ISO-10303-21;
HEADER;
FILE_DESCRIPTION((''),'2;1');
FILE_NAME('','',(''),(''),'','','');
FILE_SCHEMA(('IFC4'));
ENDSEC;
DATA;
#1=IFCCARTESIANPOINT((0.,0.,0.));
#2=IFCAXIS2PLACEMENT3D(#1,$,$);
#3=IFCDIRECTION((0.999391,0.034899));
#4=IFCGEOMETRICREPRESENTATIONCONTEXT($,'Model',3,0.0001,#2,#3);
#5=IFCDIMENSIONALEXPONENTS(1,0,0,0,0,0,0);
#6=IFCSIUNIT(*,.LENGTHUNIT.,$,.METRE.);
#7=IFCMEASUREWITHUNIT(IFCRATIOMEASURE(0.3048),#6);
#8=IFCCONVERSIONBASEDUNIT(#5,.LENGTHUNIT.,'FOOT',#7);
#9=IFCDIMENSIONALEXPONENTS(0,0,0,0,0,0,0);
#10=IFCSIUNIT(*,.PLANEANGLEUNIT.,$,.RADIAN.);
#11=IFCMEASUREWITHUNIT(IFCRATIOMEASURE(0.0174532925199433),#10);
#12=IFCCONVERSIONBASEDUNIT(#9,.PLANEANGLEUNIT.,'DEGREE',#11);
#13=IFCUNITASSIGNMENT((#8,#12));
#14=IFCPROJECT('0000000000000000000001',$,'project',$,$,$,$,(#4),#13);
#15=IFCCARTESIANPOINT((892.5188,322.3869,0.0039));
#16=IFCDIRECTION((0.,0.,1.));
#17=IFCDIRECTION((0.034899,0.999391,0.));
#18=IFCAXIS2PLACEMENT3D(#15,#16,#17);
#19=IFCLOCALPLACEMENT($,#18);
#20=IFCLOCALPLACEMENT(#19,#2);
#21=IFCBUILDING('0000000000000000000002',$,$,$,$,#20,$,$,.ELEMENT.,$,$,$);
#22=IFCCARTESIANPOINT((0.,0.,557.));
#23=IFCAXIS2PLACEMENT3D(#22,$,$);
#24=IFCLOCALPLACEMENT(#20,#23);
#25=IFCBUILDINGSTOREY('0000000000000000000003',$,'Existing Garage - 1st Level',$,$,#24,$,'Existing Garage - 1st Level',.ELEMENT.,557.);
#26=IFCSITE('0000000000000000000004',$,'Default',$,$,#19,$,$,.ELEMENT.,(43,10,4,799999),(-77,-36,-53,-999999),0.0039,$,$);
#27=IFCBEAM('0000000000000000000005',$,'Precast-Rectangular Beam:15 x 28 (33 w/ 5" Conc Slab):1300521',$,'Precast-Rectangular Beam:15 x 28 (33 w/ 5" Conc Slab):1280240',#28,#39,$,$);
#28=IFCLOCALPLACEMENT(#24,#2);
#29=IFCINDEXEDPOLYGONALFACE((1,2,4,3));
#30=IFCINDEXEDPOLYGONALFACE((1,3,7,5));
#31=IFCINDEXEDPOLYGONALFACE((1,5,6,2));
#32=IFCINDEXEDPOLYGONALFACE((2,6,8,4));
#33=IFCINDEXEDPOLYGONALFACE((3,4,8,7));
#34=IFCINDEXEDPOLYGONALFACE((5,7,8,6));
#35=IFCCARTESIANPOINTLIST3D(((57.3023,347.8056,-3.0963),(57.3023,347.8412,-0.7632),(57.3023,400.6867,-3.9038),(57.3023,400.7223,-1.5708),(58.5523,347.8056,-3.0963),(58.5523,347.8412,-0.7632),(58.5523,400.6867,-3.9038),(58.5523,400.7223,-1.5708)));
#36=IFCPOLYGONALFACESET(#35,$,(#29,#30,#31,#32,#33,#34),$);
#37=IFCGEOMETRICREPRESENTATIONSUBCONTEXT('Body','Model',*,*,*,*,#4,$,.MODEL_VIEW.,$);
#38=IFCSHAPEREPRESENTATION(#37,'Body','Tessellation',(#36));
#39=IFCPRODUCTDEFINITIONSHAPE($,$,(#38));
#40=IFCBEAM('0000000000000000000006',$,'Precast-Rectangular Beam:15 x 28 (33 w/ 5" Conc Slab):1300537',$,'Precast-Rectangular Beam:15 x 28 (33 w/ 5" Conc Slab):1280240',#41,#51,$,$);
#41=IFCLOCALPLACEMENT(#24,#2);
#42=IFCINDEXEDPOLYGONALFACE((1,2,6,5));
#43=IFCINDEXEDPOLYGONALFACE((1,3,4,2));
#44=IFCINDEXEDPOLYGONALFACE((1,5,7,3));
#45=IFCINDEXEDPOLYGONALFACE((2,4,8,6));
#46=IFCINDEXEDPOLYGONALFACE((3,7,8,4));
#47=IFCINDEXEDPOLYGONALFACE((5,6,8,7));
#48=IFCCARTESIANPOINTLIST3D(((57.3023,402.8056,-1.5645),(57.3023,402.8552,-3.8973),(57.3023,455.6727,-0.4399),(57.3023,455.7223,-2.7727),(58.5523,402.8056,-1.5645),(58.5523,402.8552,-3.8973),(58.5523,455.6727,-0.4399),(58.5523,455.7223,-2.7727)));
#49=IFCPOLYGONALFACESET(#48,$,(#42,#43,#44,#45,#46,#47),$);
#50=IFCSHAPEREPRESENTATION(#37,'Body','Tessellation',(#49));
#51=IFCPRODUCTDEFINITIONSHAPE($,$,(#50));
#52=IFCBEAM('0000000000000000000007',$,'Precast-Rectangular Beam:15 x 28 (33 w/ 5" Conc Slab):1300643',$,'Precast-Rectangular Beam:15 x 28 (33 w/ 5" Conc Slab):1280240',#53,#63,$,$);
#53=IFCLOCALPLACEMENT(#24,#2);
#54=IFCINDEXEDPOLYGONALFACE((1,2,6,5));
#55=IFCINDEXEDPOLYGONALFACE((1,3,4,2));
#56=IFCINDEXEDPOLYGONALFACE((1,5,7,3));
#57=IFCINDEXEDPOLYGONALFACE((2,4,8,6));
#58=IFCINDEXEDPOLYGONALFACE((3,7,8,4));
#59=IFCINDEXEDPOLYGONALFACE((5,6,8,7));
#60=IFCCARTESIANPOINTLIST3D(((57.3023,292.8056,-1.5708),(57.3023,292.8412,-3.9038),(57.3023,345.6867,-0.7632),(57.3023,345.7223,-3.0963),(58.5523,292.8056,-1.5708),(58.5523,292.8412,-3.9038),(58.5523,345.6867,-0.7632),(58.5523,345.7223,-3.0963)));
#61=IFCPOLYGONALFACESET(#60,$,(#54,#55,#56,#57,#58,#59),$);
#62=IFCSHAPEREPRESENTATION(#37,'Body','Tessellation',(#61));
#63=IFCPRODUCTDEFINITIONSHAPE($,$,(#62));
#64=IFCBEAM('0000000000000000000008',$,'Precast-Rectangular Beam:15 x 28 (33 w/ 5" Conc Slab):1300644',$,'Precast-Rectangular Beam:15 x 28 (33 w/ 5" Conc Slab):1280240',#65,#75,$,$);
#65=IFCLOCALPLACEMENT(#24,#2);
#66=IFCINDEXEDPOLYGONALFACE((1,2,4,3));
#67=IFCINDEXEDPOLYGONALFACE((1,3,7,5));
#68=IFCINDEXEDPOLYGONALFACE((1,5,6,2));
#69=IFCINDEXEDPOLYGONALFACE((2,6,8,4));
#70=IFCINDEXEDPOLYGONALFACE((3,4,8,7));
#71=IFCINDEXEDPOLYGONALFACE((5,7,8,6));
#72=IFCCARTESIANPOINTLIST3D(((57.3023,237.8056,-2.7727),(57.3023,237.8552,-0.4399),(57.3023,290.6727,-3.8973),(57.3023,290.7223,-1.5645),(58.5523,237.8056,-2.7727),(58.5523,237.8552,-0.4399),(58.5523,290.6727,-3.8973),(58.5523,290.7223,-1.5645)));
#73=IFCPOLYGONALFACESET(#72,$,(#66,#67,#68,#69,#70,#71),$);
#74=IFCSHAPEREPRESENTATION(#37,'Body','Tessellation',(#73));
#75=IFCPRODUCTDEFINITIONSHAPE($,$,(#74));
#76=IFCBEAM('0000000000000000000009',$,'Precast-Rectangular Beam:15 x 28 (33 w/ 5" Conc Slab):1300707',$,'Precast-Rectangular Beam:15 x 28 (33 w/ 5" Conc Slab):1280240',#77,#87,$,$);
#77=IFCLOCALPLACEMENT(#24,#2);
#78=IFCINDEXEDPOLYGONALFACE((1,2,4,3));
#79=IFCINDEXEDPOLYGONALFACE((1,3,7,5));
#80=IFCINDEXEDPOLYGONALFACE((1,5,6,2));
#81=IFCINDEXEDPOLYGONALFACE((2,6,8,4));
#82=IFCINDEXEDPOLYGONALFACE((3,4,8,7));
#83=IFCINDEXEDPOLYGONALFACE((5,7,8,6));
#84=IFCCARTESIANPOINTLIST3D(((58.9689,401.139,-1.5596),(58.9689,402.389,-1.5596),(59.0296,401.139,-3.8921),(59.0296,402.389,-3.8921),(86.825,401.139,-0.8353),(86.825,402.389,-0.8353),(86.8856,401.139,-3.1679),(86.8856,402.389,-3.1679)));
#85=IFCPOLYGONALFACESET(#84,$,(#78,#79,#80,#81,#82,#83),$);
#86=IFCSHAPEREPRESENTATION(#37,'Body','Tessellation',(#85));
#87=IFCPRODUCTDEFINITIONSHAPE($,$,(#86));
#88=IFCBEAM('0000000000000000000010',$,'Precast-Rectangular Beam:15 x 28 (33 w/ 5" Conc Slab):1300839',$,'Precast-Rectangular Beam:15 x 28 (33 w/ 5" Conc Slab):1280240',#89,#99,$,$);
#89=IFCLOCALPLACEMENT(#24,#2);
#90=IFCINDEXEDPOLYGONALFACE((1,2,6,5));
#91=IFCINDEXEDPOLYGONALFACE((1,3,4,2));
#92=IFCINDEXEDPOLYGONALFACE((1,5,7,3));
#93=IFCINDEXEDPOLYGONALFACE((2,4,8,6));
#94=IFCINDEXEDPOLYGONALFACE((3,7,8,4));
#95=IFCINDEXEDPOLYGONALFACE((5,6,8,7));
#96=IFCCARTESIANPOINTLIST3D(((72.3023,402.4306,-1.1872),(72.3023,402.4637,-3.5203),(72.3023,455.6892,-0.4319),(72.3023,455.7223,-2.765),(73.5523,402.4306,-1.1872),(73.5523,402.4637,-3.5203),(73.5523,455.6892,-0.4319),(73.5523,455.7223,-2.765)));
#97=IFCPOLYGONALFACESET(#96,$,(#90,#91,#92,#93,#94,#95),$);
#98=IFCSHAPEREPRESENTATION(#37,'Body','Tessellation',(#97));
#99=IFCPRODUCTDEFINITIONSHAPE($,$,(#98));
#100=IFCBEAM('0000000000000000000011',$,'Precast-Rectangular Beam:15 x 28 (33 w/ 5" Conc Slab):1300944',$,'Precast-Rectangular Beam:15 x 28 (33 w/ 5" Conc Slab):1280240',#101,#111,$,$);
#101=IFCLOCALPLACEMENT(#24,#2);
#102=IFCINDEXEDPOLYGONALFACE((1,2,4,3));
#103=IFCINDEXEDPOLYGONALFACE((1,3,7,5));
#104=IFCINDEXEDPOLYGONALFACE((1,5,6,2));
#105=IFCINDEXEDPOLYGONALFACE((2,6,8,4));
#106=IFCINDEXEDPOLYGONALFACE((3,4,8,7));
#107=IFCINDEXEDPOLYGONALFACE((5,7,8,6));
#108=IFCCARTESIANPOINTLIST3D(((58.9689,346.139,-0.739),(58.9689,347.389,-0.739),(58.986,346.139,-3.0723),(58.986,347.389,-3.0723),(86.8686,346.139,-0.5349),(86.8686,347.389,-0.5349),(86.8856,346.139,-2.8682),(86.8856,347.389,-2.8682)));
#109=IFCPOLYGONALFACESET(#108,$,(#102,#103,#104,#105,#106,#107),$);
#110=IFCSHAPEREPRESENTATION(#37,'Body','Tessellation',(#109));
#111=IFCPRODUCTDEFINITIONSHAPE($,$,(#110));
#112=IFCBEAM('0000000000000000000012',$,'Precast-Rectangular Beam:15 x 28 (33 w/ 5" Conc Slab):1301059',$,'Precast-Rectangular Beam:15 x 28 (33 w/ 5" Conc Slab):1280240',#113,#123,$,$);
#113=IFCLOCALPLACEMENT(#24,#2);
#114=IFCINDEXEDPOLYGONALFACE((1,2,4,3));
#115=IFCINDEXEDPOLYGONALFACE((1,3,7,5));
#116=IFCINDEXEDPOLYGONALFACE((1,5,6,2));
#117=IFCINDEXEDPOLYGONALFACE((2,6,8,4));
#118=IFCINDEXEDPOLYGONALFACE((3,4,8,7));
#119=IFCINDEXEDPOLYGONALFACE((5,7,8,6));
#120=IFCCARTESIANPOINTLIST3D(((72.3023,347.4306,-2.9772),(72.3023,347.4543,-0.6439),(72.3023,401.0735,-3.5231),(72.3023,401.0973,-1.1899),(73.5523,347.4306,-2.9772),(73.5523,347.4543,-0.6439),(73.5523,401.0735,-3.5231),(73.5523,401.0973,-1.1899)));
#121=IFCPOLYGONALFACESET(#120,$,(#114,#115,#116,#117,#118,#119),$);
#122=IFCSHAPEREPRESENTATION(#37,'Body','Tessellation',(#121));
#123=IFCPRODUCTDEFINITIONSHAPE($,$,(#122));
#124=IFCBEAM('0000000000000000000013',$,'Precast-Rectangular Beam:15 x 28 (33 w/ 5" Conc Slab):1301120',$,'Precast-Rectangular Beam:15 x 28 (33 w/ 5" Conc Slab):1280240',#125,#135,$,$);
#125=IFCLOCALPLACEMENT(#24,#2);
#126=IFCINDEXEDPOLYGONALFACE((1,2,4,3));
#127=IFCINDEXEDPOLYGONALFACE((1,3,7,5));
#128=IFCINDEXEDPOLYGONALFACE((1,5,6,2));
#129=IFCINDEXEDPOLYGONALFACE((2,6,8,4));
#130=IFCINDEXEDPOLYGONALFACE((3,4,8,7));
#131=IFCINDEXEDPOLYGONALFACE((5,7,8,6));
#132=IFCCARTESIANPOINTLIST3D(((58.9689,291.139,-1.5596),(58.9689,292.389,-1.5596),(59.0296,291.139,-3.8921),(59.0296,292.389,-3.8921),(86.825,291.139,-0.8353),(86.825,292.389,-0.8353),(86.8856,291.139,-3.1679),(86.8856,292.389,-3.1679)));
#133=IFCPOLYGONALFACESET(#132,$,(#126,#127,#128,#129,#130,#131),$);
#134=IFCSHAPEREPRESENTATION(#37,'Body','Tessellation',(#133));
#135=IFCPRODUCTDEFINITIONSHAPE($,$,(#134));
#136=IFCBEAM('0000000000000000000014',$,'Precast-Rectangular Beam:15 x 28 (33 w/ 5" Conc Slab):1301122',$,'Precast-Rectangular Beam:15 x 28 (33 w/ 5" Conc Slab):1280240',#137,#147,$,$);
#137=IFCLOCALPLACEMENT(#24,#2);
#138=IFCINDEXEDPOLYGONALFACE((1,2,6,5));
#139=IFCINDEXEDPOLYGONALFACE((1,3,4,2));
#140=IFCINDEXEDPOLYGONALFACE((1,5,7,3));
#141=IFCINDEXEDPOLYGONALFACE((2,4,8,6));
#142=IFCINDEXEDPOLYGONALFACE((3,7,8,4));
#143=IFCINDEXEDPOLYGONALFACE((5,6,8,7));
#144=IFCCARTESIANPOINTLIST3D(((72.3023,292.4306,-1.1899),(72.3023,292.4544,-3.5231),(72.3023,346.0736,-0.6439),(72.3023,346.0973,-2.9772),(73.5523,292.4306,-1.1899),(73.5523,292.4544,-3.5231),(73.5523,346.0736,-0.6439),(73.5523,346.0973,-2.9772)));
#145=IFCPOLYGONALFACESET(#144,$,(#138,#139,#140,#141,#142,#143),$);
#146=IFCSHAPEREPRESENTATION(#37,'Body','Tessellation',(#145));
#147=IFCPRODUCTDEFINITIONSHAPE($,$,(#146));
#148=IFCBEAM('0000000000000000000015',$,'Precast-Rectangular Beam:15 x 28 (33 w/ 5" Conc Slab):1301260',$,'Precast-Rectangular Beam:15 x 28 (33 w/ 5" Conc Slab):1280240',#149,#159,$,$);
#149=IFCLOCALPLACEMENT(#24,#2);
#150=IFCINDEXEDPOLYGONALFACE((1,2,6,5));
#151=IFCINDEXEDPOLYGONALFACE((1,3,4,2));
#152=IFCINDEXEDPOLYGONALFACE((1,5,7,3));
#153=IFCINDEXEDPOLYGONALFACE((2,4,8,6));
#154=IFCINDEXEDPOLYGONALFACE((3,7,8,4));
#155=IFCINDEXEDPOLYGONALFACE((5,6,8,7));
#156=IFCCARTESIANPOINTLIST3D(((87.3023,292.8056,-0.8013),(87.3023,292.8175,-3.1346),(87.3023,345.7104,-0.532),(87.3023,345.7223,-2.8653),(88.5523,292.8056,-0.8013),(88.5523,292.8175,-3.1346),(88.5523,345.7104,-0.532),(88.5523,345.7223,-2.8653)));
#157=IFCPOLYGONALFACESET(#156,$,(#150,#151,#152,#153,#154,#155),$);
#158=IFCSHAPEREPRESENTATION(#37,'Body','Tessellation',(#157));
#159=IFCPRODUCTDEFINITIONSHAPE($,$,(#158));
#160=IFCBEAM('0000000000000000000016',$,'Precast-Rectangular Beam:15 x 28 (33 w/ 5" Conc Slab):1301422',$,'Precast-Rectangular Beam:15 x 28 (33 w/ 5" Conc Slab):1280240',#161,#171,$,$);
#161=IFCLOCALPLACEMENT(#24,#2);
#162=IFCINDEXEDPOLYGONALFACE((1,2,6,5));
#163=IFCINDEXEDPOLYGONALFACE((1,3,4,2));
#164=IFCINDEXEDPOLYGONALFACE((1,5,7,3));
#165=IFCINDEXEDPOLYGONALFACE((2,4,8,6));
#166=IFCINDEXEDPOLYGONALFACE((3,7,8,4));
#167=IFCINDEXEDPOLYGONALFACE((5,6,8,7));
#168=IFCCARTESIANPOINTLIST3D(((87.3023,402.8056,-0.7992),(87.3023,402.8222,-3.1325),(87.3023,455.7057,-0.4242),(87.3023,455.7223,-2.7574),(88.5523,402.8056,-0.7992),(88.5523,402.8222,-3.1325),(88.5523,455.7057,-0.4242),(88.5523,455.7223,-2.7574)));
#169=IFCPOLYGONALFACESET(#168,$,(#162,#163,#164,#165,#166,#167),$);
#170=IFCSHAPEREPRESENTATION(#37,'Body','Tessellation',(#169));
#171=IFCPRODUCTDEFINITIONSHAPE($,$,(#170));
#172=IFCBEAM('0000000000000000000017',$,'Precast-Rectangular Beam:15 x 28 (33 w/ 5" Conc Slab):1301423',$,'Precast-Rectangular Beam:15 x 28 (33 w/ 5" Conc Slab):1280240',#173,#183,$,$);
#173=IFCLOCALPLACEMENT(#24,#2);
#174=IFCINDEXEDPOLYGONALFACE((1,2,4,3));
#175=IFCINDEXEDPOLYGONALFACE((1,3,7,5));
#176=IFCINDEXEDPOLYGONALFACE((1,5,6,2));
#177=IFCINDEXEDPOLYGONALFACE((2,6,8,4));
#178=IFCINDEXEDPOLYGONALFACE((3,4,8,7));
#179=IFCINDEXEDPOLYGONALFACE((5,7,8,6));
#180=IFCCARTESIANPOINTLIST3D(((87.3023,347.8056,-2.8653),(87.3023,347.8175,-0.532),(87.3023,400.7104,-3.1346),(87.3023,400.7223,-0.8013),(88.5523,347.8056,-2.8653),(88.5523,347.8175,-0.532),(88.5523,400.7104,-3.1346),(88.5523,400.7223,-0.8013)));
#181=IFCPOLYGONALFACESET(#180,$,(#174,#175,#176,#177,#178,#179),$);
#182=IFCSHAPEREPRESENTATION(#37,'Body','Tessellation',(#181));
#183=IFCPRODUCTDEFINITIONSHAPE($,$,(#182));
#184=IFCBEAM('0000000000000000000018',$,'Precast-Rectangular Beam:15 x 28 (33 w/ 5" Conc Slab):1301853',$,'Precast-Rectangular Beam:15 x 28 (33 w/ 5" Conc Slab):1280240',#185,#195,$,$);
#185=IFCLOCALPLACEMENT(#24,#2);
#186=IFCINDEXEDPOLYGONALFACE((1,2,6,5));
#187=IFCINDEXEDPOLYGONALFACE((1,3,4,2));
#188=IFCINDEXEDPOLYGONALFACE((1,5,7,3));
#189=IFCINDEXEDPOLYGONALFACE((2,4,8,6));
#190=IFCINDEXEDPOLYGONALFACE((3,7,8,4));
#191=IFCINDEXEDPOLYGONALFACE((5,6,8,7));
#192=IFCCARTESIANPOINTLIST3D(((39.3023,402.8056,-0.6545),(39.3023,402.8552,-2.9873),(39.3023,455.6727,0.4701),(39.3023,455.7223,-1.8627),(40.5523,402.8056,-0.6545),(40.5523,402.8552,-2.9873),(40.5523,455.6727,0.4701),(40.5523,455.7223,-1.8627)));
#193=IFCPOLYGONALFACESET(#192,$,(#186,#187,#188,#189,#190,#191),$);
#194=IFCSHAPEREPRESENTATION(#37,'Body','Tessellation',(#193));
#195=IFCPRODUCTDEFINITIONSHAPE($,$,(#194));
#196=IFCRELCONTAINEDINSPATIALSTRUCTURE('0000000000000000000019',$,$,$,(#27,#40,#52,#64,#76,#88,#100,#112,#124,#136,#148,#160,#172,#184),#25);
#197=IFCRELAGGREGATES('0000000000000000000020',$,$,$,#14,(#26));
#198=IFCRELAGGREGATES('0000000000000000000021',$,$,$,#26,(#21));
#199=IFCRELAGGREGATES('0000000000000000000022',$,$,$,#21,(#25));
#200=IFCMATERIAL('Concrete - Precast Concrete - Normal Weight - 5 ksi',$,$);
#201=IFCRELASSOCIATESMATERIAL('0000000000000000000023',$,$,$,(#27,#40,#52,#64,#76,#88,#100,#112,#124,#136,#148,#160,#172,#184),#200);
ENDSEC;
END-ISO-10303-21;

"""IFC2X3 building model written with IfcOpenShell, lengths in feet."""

from ifc_helpers import new_model, entity, si_unit, converted_unit, direction, frame, frame_2d, origin, origin_2d_with_axis, place, context, subcontext, project, spatial, rectangle, extrude, material, element, save


model = new_model("IFC2X3")

# Units and contexts
model_context = context("Model", 3, precision=0.0001, world=origin(), true_north=direction((0.999391, 0.034899)))
body_context = subcontext(model_context, "Body", "Model", "MODEL_VIEW")
ifc_project = project(units=[converted_unit("LENGTHUNIT", "FOOT", entity("IfcRatioMeasure", 0.3048), si_unit("LENGTHUNIT", "METRE"), dimensions=[1, 0, 0, 0, 0, 0, 0]), converted_unit("PLANEANGLEUNIT", "DEGREE", entity("IfcRatioMeasure", 0.0174532925199433), si_unit("PLANEANGLEUNIT", "RADIAN"), dimensions=[0, 0, 0, 0, 0, 0, 0])], contexts=[model_context])

# Site, building, storey
site_placement = place(None, frame((892.5188, 322.3869, 0.0039), z_axis=(0.0, 0.0, 1.0), x_axis=(0.034899, 0.999391, 0.0)))
site = spatial("IfcSite", under=ifc_project, at=site_placement, Name="Default", CompositionType="ELEMENT", RefLatitude=(43, 10, 4, 799999), RefLongitude=(-77, -36, -53, -999999), RefElevation=0.0039)
building_placement = place(site_placement, origin())
building = spatial("IfcBuilding", under=site, at=building_placement, CompositionType="ELEMENT")
storey_placement = place(building_placement, frame((0.0, 0.0, 557.0)))
storey = spatial("IfcBuildingStorey", under=building, at=storey_placement, Name="Existing Garage - 1st Level", LongName="Existing Garage - 1st Level", CompositionType="ELEMENT", Elevation=557.0)

# Beams
ifc_material_1 = material(Name="Concrete - Precast Concrete - Normal Weight - 5 ksi")
beam_1_placement = place(storey_placement, frame((57.9273, 346.764, -0.7467), z_axis=(0.0, 0.01527, 0.999883), x_axis=(0.0, 0.999883, -0.01527)))
element("IfcBeam", 1, at=beam_1_placement, inside=storey, material=ifc_material_1, Name="Precast-Rectangular Beam:15 x 28 (33 w/ 5\" Conc Slab):1300521", ObjectType="Precast-Rectangular Beam:15 x 28 (33 w/ 5\" Conc Slab):1280240", context=body_context, shape_type="SweptSolid", body=[
    extrude(rectangle(XDim=2.3333, YDim=1.25, at=origin_2d_with_axis()), frame((1.0774, 0.0, -1.1667), z_axis=(1.0, 0.0, 0.0), x_axis=(0.0, 0.0, -1.0)), (0.0, 0.0, 1.0), 52.8872),
])
beam_2_placement = place(storey_placement, frame((57.9273, 401.764, -1.5867), z_axis=(0.0, -0.021268, 0.999774), x_axis=(0.0, 0.999774, 0.021268)))
element("IfcBeam", 2, at=beam_2_placement, inside=storey, material=ifc_material_1, Name="Precast-Rectangular Beam:15 x 28 (33 w/ 5\" Conc Slab):1300537", ObjectType="Precast-Rectangular Beam:15 x 28 (33 w/ 5\" Conc Slab):1280240", context=body_context, shape_type="SweptSolid", body=[
    extrude(rectangle(XDim=2.3333, YDim=1.25, at=origin_2d_with_axis()), frame((1.0419, 0.0, -1.1667), z_axis=(1.0, 0.0, 0.0), x_axis=(0.0, 0.0, -1.0)), (0.0, 0.0, 1.0), 52.879),
])
beam_3_placement = place(storey_placement, frame((57.9273, 346.764, -0.7467), z_axis=(0.0, -0.01527, 0.999883), x_axis=(0.0, -0.999883, -0.01527)))
element("IfcBeam", 3, at=beam_3_placement, inside=storey, material=ifc_material_1, Name="Precast-Rectangular Beam:15 x 28 (33 w/ 5\" Conc Slab):1300643", ObjectType="Precast-Rectangular Beam:15 x 28 (33 w/ 5\" Conc Slab):1280240", context=body_context, shape_type="SweptSolid", body=[
    extrude(rectangle(XDim=2.3333, YDim=1.25, at=frame_2d((0.0, 0.0), x_axis=(1.0, 0.0))), frame((1.0774, 0.0, -1.1667), z_axis=(1.0, 0.0, 0.0), x_axis=(0.0, 0.0, -1.0)), (0.0, 0.0, 1.0), 52.8872),
])
beam_4_placement = place(storey_placement, frame((57.9273, 291.764, -1.5867), z_axis=(0.0, 0.021268, 0.999774), x_axis=(0.0, -0.999774, 0.021268)))
element("IfcBeam", 4, at=beam_4_placement, inside=storey, material=ifc_material_1, Name="Precast-Rectangular Beam:15 x 28 (33 w/ 5\" Conc Slab):1300644", ObjectType="Precast-Rectangular Beam:15 x 28 (33 w/ 5\" Conc Slab):1280240", context=body_context, shape_type="SweptSolid", body=[
    extrude(rectangle(XDim=2.3333, YDim=1.25, at=frame_2d((0.0, 0.0), x_axis=(1.0, 0.0))), frame((1.0419, 0.0, -1.1667), z_axis=(1.0, 0.0, 0.0), x_axis=(0.0, 0.0, -1.0)), (0.0, 0.0, 1.0), 52.879),
])
beam_5_placement = place(storey_placement, frame((57.9273, 401.764, -1.5867), z_axis=(-0.025991, 0.0, 0.999662), x_axis=(0.999662, 0.0, 0.025991)))
element("IfcBeam", 5, at=beam_5_placement, inside=storey, material=ifc_material_1, Name="Precast-Rectangular Beam:15 x 28 (33 w/ 5\" Conc Slab):1300707", ObjectType="Precast-Rectangular Beam:15 x 28 (33 w/ 5\" Conc Slab):1280240", context=body_context, shape_type="SweptSolid", body=[
    extrude(rectangle(XDim=2.3333, YDim=1.25, at=frame_2d((0.0, 0.0), x_axis=(1.0, 0.0))), frame((1.042, 0.0, -1.1667), z_axis=(1.0, 0.0, 0.0), x_axis=(0.0, 0.0, -1.0)), (0.0, 0.0, 1.0), 27.8655),
])
beam_6_placement = place(storey_placement, frame((72.9273, 456.764, -0.4167), z_axis=(0.0, -0.01418, 0.999899), x_axis=(0.0, -0.999899, -0.01418)))
element("IfcBeam", 6, at=beam_6_placement, inside=storey, material=ifc_material_1, Name="Precast-Rectangular Beam:15 x 28 (33 w/ 5\" Conc Slab):1300839", ObjectType="Precast-Rectangular Beam:15 x 28 (33 w/ 5\" Conc Slab):1280240", context=body_context, shape_type="SweptSolid", body=[
    extrude(rectangle(XDim=2.3333, YDim=1.25, at=frame_2d((0.0, 0.0), x_axis=(1.0, 0.0))), frame((1.0749, 0.0, -1.1667), z_axis=(1.0, 0.0, 0.0), x_axis=(0.0, 0.0, -1.0)), (0.0, 0.0, 1.0), 53.2639),
])
beam_7_placement = place(storey_placement, frame((57.9273, 346.764, -0.7467), z_axis=(-0.007317, 0.0, 0.999973), x_axis=(0.999973, 0.0, 0.007317)))
element("IfcBeam", 7, at=beam_7_placement, inside=storey, material=ifc_material_1, Name="Precast-Rectangular Beam:15 x 28 (33 w/ 5\" Conc Slab):1300944", ObjectType="Precast-Rectangular Beam:15 x 28 (33 w/ 5\" Conc Slab):1280240", context=body_context, shape_type="SweptSolid", body=[
    extrude(rectangle(XDim=2.3333, YDim=1.25, at=origin_2d_with_axis()), frame((1.0417, 0.0, -1.1667), z_axis=(1.0, 0.0, 0.0), x_axis=(0.0, 0.0, -1.0)), (0.0, 0.0, 1.0), 27.9004),
])
beam_8_placement = place(storey_placement, frame((72.9273, 346.764, -0.6369), z_axis=(0.0, 0.010177, 0.999948), x_axis=(0.0, 0.999948, -0.010177)))
element("IfcBeam", 8, at=beam_8_placement, inside=storey, material=ifc_material_1, Name="Precast-Rectangular Beam:15 x 28 (33 w/ 5\" Conc Slab):1301059", ObjectType="Precast-Rectangular Beam:15 x 28 (33 w/ 5\" Conc Slab):1280240", context=body_context, shape_type="SweptSolid", body=[
    extrude(rectangle(XDim=2.3333, YDim=1.25, at=frame_2d((0.0, 0.0), x_axis=(1.0, 0.0))), frame((0.6904, 0.0, -1.1667), z_axis=(1.0, 0.0, 0.0), x_axis=(0.0, 0.0, -1.0)), (0.0, 0.0, 1.0), 53.6457),
])
beam_9_placement = place(storey_placement, frame((57.9273, 291.764, -1.5867), z_axis=(-0.025991, 0.0, 0.999662), x_axis=(0.999662, 0.0, 0.025991)))
element("IfcBeam", 9, at=beam_9_placement, inside=storey, material=ifc_material_1, Name="Precast-Rectangular Beam:15 x 28 (33 w/ 5\" Conc Slab):1301120", ObjectType="Precast-Rectangular Beam:15 x 28 (33 w/ 5\" Conc Slab):1280240", context=body_context, shape_type="SweptSolid", body=[
    extrude(rectangle(XDim=2.3333, YDim=1.25, at=origin_2d_with_axis()), frame((1.042, 0.0, -1.1667), z_axis=(1.0, 0.0, 0.0), x_axis=(0.0, 0.0, -1.0)), (0.0, 0.0, 1.0), 27.8655),
])
beam_10_placement = place(storey_placement, frame((72.9273, 346.764, -0.6369), z_axis=(0.0, -0.010177, 0.999948), x_axis=(0.0, -0.999948, -0.010177)))
element("IfcBeam", 10, at=beam_10_placement, inside=storey, material=ifc_material_1, Name="Precast-Rectangular Beam:15 x 28 (33 w/ 5\" Conc Slab):1301122", ObjectType="Precast-Rectangular Beam:15 x 28 (33 w/ 5\" Conc Slab):1280240", context=body_context, shape_type="SweptSolid", body=[
    extrude(rectangle(XDim=2.3333, YDim=1.25, at=frame_2d((0.0, 0.0), x_axis=(1.0, 0.0))), frame((0.6904, 0.0, -1.1667), z_axis=(1.0, 0.0, 0.0), x_axis=(0.0, 0.0, -1.0)), (0.0, 0.0, 1.0), 53.6457),
])
beam_11_placement = place(storey_placement, frame((87.9273, 346.764, -0.5267), z_axis=(0.0, -0.00509, 0.999987), x_axis=(0.0, -0.999987, -0.00509)))
element("IfcBeam", 11, at=beam_11_placement, inside=storey, material=ifc_material_1, Name="Precast-Rectangular Beam:15 x 28 (33 w/ 5\" Conc Slab):1301260", ObjectType="Precast-Rectangular Beam:15 x 28 (33 w/ 5\" Conc Slab):1280240", context=body_context, shape_type="SweptSolid", body=[
    extrude(rectangle(XDim=2.3333, YDim=1.25, at=frame_2d((0.0, 0.0), x_axis=(1.0, 0.0))), frame((1.0536, 0.0, -1.1667), z_axis=(1.0, 0.0, 0.0), x_axis=(0.0, 0.0, -1.0)), (0.0, 0.0, 1.0), 52.9055),
])
beam_12_placement = place(storey_placement, frame((87.9273, 456.764, -0.4167), z_axis=(0.0, -0.00709, 0.999975), x_axis=(0.0, -0.999975, -0.00709)))
element("IfcBeam", 12, at=beam_12_placement, inside=storey, material=ifc_material_1, Name="Precast-Rectangular Beam:15 x 28 (33 w/ 5\" Conc Slab):1301422", ObjectType="Precast-Rectangular Beam:15 x 28 (33 w/ 5\" Conc Slab):1280240", context=body_context, shape_type="SweptSolid", body=[
    extrude(rectangle(XDim=2.3333, YDim=1.25, at=frame_2d((0.0, 0.0), x_axis=(1.0, 0.0))), frame((1.0582, 0.0, -1.1667), z_axis=(1.0, 0.0, 0.0), x_axis=(0.0, 0.0, -1.0)), (0.0, 0.0, 1.0), 52.9015),
])
beam_13_placement = place(storey_placement, frame((87.9273, 346.764, -0.5267), z_axis=(0.0, 0.00509, 0.999987), x_axis=(0.0, 0.999987, -0.00509)))
element("IfcBeam", 13, at=beam_13_placement, inside=storey, material=ifc_material_1, Name="Precast-Rectangular Beam:15 x 28 (33 w/ 5\" Conc Slab):1301423", ObjectType="Precast-Rectangular Beam:15 x 28 (33 w/ 5\" Conc Slab):1280240", context=body_context, shape_type="SweptSolid", body=[
    extrude(rectangle(XDim=2.3333, YDim=1.25, at=frame_2d((0.0, 0.0), x_axis=(1.0, 0.0))), frame((1.0536, 0.0, -1.1667), z_axis=(1.0, 0.0, 0.0), x_axis=(0.0, 0.0, -1.0)), (0.0, 0.0, 1.0), 52.9055),
])
beam_14_placement = place(storey_placement, frame((39.9273, 456.764, 0.4933), z_axis=(0.0, -0.021268, 0.999774), x_axis=(0.0, -0.999774, -0.021268)))
element("IfcBeam", 14, at=beam_14_placement, inside=storey, material=ifc_material_1, Name="Precast-Rectangular Beam:15 x 28 (33 w/ 5\" Conc Slab):1301853", ObjectType="Precast-Rectangular Beam:15 x 28 (33 w/ 5\" Conc Slab):1280240", context=body_context, shape_type="SweptSolid", body=[
    extrude(rectangle(XDim=2.3333, YDim=1.25, at=frame_2d((0.0, 0.0), x_axis=(1.0, 0.0))), frame((1.0915, 0.0, -1.1667), z_axis=(1.0, 0.0, 0.0), x_axis=(0.0, 0.0, -1.0)), (0.0, 0.0, 1.0), 52.879),
])

save(model, "model.ifc")
